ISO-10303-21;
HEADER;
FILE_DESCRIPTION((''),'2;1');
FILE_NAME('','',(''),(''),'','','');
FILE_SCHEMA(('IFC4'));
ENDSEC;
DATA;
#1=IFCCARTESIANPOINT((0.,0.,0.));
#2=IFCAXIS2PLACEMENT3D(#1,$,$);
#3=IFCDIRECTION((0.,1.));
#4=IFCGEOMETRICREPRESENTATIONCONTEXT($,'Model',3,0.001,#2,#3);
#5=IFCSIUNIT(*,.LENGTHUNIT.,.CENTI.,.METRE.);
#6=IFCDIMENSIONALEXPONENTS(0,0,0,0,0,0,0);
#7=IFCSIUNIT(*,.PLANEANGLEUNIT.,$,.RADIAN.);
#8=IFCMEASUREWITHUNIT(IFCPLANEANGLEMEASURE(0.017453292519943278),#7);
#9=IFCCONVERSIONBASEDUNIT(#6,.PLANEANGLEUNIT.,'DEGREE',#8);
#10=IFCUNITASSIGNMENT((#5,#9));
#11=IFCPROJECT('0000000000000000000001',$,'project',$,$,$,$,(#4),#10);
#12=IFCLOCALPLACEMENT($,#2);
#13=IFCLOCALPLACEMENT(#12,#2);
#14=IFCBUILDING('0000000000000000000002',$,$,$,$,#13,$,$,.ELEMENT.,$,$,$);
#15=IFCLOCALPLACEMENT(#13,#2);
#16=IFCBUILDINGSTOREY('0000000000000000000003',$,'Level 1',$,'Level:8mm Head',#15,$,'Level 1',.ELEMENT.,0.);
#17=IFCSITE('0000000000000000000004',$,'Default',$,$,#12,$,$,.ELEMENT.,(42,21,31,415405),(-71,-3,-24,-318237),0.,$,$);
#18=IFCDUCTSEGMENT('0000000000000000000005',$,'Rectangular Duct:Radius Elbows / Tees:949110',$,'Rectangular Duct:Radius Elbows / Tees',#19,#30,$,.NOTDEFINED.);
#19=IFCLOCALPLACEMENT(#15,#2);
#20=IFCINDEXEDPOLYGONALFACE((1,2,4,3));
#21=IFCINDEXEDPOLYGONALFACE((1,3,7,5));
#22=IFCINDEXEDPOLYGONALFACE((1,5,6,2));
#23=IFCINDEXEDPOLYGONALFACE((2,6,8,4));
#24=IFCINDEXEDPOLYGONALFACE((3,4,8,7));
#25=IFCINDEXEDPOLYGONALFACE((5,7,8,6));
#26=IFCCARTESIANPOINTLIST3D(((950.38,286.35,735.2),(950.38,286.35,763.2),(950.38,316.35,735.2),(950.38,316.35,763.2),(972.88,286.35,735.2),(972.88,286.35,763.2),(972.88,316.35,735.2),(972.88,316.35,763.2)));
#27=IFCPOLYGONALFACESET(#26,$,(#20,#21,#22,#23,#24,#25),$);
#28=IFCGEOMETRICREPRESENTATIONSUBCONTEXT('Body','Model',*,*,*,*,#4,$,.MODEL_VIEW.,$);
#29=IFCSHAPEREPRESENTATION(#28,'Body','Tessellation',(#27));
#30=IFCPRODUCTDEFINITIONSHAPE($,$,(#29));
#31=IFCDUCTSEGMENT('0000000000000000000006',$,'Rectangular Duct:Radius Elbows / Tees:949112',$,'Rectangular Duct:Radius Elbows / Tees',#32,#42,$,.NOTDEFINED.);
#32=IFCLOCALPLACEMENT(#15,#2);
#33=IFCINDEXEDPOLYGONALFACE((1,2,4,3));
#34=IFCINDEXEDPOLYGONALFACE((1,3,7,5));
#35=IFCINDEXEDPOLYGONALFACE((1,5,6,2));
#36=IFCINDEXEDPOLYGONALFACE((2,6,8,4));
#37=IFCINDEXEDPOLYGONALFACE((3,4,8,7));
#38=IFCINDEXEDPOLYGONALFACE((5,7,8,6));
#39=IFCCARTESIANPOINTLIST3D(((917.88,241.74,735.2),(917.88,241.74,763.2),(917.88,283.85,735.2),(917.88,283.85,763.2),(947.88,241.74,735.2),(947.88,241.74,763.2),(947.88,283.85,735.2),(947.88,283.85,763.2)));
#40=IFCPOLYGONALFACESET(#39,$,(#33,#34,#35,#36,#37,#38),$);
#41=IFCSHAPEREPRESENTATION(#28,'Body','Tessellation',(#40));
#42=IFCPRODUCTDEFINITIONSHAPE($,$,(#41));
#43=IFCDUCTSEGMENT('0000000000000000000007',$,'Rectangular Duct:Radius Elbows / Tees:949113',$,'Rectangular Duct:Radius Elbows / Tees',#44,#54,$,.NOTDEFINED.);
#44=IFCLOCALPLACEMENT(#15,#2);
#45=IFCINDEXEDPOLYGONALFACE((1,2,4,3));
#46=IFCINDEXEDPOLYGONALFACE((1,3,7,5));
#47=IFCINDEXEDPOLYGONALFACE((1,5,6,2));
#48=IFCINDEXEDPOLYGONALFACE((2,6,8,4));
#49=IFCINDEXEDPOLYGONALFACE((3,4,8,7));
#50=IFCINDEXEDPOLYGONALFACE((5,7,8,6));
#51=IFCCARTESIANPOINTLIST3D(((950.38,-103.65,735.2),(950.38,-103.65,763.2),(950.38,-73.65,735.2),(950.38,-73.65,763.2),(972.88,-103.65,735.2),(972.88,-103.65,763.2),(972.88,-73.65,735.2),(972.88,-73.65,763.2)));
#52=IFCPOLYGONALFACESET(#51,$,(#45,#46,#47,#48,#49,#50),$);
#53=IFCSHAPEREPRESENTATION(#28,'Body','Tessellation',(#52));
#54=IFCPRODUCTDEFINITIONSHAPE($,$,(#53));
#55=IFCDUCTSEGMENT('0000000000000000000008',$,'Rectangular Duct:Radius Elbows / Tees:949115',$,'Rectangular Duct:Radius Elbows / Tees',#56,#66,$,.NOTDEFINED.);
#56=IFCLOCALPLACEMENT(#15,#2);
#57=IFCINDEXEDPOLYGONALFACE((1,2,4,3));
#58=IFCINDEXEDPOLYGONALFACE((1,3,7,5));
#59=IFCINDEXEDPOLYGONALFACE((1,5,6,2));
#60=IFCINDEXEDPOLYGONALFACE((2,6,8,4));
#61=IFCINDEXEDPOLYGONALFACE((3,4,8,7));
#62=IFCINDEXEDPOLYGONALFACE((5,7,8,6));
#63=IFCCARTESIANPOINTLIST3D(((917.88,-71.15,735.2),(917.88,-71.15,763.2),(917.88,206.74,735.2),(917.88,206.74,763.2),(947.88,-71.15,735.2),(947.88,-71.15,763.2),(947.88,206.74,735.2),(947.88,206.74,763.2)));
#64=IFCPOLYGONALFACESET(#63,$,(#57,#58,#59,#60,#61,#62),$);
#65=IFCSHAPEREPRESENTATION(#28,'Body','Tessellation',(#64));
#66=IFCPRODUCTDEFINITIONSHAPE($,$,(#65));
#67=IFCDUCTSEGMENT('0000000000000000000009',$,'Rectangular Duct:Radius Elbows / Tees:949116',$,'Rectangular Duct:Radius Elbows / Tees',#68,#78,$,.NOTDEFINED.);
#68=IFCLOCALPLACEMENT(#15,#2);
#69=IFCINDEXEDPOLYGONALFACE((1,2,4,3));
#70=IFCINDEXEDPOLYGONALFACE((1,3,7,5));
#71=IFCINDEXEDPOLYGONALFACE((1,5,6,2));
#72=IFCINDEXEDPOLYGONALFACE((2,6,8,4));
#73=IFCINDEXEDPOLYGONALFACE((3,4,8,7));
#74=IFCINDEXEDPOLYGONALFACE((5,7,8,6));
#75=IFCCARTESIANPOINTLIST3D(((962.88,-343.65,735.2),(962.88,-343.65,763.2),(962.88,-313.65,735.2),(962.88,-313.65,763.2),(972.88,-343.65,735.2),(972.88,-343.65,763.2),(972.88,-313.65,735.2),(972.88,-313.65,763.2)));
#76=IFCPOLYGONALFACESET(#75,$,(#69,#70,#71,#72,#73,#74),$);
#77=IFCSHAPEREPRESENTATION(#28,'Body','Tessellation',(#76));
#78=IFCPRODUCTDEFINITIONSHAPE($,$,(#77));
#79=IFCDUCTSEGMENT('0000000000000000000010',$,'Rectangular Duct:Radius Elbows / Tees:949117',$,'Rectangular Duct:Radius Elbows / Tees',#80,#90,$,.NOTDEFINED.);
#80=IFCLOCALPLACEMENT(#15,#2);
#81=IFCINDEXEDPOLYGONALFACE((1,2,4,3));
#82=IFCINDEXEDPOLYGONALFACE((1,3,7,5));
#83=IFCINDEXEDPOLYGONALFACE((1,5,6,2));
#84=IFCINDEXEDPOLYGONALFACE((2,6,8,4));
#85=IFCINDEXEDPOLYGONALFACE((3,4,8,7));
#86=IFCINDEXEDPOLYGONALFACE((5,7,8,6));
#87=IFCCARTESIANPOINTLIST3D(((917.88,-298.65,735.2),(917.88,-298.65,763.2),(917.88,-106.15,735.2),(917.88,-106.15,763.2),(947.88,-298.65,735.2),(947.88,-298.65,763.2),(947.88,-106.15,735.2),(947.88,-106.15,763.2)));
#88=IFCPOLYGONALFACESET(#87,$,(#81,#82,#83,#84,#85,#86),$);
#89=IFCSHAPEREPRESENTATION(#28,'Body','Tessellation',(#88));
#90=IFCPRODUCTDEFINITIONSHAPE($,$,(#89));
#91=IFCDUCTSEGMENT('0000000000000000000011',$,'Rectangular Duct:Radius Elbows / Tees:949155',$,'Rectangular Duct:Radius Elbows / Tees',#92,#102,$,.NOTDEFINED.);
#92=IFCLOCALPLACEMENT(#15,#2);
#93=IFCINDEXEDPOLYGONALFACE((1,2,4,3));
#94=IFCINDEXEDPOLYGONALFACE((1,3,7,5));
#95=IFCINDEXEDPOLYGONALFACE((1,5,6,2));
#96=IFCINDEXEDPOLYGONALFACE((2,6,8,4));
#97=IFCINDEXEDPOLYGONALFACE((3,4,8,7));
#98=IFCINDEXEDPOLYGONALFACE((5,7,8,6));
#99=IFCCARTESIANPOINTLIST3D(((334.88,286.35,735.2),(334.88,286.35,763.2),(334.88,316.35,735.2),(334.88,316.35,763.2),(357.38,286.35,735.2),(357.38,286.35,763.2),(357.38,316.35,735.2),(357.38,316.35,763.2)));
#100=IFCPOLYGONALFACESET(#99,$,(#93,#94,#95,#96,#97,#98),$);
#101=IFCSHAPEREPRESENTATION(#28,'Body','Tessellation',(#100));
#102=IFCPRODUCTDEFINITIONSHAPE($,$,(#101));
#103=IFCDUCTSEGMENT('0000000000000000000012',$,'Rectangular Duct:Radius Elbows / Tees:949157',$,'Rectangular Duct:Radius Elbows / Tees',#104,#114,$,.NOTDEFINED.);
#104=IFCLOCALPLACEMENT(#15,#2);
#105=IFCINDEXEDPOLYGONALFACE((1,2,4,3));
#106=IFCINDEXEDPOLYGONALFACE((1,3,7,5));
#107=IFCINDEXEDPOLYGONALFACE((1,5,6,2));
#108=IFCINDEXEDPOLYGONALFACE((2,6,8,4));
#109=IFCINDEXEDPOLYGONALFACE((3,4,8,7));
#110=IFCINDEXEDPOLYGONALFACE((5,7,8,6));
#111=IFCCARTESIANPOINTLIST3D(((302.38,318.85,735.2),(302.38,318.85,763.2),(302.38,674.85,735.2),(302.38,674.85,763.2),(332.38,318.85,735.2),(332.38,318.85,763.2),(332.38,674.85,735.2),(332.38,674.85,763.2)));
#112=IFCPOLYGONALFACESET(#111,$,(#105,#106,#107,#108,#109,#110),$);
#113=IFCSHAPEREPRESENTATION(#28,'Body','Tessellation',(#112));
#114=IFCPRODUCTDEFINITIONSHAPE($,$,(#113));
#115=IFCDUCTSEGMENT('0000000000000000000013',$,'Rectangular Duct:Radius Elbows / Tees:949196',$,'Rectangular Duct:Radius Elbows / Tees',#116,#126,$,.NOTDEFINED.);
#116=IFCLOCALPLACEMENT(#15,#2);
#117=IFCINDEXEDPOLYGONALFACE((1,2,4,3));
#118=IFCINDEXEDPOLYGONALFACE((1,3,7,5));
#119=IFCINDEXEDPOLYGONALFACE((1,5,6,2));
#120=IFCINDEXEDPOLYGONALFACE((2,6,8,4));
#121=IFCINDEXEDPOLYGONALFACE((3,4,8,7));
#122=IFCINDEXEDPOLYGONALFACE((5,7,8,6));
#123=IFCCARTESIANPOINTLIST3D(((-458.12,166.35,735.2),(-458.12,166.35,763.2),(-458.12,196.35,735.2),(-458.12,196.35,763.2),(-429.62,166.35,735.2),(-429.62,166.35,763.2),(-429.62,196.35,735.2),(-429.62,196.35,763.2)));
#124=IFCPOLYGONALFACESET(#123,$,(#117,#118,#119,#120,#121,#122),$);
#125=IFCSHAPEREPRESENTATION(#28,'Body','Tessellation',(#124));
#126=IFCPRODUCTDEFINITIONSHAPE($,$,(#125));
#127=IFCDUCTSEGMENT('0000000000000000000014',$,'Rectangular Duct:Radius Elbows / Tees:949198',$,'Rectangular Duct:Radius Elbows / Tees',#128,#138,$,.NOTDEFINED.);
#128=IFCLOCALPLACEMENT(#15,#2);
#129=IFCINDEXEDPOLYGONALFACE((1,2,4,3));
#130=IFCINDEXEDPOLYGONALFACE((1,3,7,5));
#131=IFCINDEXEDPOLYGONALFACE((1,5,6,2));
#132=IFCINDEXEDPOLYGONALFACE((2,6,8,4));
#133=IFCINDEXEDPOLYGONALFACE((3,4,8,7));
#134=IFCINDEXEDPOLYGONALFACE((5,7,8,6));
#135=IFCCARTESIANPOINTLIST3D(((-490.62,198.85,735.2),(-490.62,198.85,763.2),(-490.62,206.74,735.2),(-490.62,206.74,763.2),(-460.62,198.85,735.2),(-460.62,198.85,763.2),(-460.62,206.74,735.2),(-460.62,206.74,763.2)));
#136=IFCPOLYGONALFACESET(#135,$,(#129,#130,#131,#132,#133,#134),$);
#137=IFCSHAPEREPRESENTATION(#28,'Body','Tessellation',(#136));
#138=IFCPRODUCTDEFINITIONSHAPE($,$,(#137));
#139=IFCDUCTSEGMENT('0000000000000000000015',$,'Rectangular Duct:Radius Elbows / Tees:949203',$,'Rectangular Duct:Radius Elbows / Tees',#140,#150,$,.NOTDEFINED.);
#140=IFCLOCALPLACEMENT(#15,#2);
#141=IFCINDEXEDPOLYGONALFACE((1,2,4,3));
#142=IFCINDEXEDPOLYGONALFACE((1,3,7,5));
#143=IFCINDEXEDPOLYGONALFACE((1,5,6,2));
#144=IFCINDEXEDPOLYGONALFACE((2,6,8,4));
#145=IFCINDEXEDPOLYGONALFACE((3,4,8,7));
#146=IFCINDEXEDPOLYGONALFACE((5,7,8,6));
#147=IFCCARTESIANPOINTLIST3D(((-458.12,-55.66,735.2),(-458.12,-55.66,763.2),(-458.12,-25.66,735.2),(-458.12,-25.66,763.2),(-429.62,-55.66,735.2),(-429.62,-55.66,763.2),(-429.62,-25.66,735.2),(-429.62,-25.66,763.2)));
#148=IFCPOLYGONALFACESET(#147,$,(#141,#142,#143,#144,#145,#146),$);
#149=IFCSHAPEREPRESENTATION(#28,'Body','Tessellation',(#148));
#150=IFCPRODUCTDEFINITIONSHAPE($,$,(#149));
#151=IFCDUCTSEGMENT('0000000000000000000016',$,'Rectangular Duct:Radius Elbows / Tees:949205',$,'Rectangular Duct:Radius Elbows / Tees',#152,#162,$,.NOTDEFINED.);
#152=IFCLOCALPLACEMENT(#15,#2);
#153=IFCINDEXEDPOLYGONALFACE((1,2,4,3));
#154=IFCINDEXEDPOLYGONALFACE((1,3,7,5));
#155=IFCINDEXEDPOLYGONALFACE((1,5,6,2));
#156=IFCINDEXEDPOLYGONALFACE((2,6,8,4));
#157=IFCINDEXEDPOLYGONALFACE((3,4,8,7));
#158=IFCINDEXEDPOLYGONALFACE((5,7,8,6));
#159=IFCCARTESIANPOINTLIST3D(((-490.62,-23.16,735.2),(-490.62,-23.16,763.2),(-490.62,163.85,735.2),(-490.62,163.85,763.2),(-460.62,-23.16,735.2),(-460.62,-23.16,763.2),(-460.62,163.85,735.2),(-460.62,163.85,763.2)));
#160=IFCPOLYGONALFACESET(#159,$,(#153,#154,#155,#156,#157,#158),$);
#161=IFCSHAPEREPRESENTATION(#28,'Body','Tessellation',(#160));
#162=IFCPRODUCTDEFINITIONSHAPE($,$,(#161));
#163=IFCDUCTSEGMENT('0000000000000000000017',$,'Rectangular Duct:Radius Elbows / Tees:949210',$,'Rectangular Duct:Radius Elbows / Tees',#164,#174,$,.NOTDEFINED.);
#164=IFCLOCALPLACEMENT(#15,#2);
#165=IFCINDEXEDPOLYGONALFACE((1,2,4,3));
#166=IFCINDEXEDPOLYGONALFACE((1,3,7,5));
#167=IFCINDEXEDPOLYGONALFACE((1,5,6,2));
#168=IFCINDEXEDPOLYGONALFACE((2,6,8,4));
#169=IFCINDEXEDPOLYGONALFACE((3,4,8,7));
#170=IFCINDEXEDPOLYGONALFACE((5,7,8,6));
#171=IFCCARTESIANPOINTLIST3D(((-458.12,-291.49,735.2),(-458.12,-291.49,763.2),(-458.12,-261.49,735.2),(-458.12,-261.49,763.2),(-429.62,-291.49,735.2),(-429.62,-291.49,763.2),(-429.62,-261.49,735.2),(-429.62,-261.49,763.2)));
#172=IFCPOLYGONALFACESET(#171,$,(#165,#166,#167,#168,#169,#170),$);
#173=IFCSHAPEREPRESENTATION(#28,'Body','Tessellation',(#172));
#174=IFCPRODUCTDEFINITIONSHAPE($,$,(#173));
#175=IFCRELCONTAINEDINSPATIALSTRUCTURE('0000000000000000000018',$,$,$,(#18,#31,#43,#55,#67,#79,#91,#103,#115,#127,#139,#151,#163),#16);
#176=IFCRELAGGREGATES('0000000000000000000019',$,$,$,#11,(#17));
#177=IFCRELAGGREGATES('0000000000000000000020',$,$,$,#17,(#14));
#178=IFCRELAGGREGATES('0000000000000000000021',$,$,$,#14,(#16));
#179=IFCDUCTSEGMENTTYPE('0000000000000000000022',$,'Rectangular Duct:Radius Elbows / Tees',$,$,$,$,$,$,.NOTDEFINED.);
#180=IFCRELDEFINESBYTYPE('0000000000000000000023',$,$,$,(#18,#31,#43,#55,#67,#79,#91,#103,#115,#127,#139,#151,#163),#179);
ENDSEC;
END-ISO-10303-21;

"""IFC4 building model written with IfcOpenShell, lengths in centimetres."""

from ifc_helpers import new_model, entity, si_unit, converted_unit, direction, frame, origin, place, context, subcontext, project, spatial, indexed_curve, outline, extrude, type_object, element, save


model = new_model("IFC4")

# Units and contexts
model_context = context("Model", 3, precision=0.001, world=origin(), true_north=direction((0.0, 1.0)))
body_context = subcontext(model_context, "Body", "Model", "MODEL_VIEW")
ifc_project = project(units=[si_unit("LENGTHUNIT", "METRE", prefix="CENTI"), converted_unit("PLANEANGLEUNIT", "DEGREE", entity("IfcPlaneAngleMeasure", 0.017453292519943278), si_unit("PLANEANGLEUNIT", "RADIAN"), dimensions=[0, 0, 0, 0, 0, 0, 0])], contexts=[model_context])

# Site, building, storey
site_placement = place(None, origin())
site = spatial("IfcSite", under=ifc_project, at=site_placement, Name="Default", CompositionType="ELEMENT", RefLatitude=(42, 21, 31, 415405), RefLongitude=(-71, -3, -24, -318237), RefElevation=0.0)
building_placement = place(site_placement, origin())
building = spatial("IfcBuilding", under=site, at=building_placement, CompositionType="ELEMENT")
storey_placement = place(building_placement, origin())
storey = spatial("IfcBuildingStorey", under=building, at=storey_placement, Name="Level 1", ObjectType="Level:8mm Head", LongName="Level 1", CompositionType="ELEMENT", Elevation=0.0)

# Duct segments
duct_segment_type_1 = type_object("IfcDuctSegmentType", Name="Rectangular Duct:Radius Elbows / Tees", PredefinedType="NOTDEFINED")
duct_segment_1_placement = place(storey_placement, origin())
element("IfcDuctSegment", 1, at=duct_segment_1_placement, inside=storey, type_object=duct_segment_type_1, Name="Rectangular Duct:Radius Elbows / Tees:949110", ObjectType="Rectangular Duct:Radius Elbows / Tees", PredefinedType="NOTDEFINED", context=body_context, shape_type="SweptSolid", body=[
    extrude(outline(indexed_curve([(-11.25, -15.0), (11.25, -15.0), (11.25, 15.0), (-11.25, 15.0), (-11.25, -15.0)], self_intersect=False)), frame((961.63, 301.35, 735.2)), (0.0, 0.0, 1.0), 28.0),
])
duct_segment_2_placement = place(storey_placement, origin())
element("IfcDuctSegment", 2, at=duct_segment_2_placement, inside=storey, type_object=duct_segment_type_1, Name="Rectangular Duct:Radius Elbows / Tees:949112", ObjectType="Rectangular Duct:Radius Elbows / Tees", PredefinedType="NOTDEFINED", context=body_context, shape_type="SweptSolid", body=[
    extrude(outline(indexed_curve([(-21.05, -15.0), (21.05, -15.0), (21.05, 15.0), (-21.05, 15.0), (-21.05, -15.0)], self_intersect=False)), frame((932.88, 262.79, 735.2), z_axis=(0.0, 0.0, 1.0), x_axis=(0.0, 1.0, 0.0)), (0.0, 0.0, 1.0), 28.0),
])
duct_segment_3_placement = place(storey_placement, origin())
element("IfcDuctSegment", 3, at=duct_segment_3_placement, inside=storey, type_object=duct_segment_type_1, Name="Rectangular Duct:Radius Elbows / Tees:949113", ObjectType="Rectangular Duct:Radius Elbows / Tees", PredefinedType="NOTDEFINED", context=body_context, shape_type="SweptSolid", body=[
    extrude(outline(indexed_curve([(-11.25, -15.0), (11.25, -15.0), (11.25, 15.0), (-11.25, 15.0), (-11.25, -15.0)], self_intersect=False)), frame((961.63, -88.65, 735.2)), (0.0, 0.0, 1.0), 28.0),
])
duct_segment_4_placement = place(storey_placement, origin())
element("IfcDuctSegment", 4, at=duct_segment_4_placement, inside=storey, type_object=duct_segment_type_1, Name="Rectangular Duct:Radius Elbows / Tees:949115", ObjectType="Rectangular Duct:Radius Elbows / Tees", PredefinedType="NOTDEFINED", context=body_context, shape_type="SweptSolid", body=[
    extrude(outline(indexed_curve([(-138.95, -15.0), (138.95, -15.0), (138.95, 15.0), (-138.95, 15.0), (-138.95, -15.0)], self_intersect=False)), frame((932.88, 67.79, 735.2), z_axis=(0.0, 0.0, 1.0), x_axis=(0.0, -1.0, 0.0)), (0.0, 0.0, 1.0), 28.0),
])
duct_segment_5_placement = place(storey_placement, origin())
element("IfcDuctSegment", 5, at=duct_segment_5_placement, inside=storey, type_object=duct_segment_type_1, Name="Rectangular Duct:Radius Elbows / Tees:949116", ObjectType="Rectangular Duct:Radius Elbows / Tees", PredefinedType="NOTDEFINED", context=body_context, shape_type="SweptSolid", body=[
    extrude(outline(indexed_curve([(-5.0, -15.0), (5.0, -15.0), (5.0, 15.0), (-5.0, 15.0), (-5.0, -15.0)], self_intersect=False)), frame((967.88, -328.65, 735.2)), (0.0, 0.0, 1.0), 28.0),
])
duct_segment_6_placement = place(storey_placement, origin())
element("IfcDuctSegment", 6, at=duct_segment_6_placement, inside=storey, type_object=duct_segment_type_1, Name="Rectangular Duct:Radius Elbows / Tees:949117", ObjectType="Rectangular Duct:Radius Elbows / Tees", PredefinedType="NOTDEFINED", context=body_context, shape_type="SweptSolid", body=[
    extrude(outline(indexed_curve([(-96.25, -15.0), (96.25, -15.0), (96.25, 15.0), (-96.25, 15.0), (-96.25, -15.0)], self_intersect=False)), frame((932.88, -202.4, 735.2), z_axis=(0.0, 0.0, 1.0), x_axis=(0.0, -1.0, 0.0)), (0.0, 0.0, 1.0), 28.0),
])
duct_segment_7_placement = place(storey_placement, origin())
element("IfcDuctSegment", 7, at=duct_segment_7_placement, inside=storey, type_object=duct_segment_type_1, Name="Rectangular Duct:Radius Elbows / Tees:949155", ObjectType="Rectangular Duct:Radius Elbows / Tees", PredefinedType="NOTDEFINED", context=body_context, shape_type="SweptSolid", body=[
    extrude(outline(indexed_curve([(-11.25, -15.0), (11.25, -15.0), (11.25, 15.0), (-11.25, 15.0), (-11.25, -15.0)], self_intersect=False)), frame((346.13, 301.35, 735.2)), (0.0, 0.0, 1.0), 28.0),
])
duct_segment_8_placement = place(storey_placement, origin())
element("IfcDuctSegment", 8, at=duct_segment_8_placement, inside=storey, type_object=duct_segment_type_1, Name="Rectangular Duct:Radius Elbows / Tees:949157", ObjectType="Rectangular Duct:Radius Elbows / Tees", PredefinedType="NOTDEFINED", context=body_context, shape_type="SweptSolid", body=[
    extrude(outline(indexed_curve([(-178.0, -15.0), (178.0, -15.0), (178.0, 15.0), (-178.0, 15.0), (-178.0, -15.0)], self_intersect=False)), frame((317.38, 496.85, 735.2), z_axis=(0.0, 0.0, 1.0), x_axis=(0.0, -1.0, 0.0)), (0.0, 0.0, 1.0), 28.0),
])
duct_segment_9_placement = place(storey_placement, origin())
element("IfcDuctSegment", 9, at=duct_segment_9_placement, inside=storey, type_object=duct_segment_type_1, Name="Rectangular Duct:Radius Elbows / Tees:949196", ObjectType="Rectangular Duct:Radius Elbows / Tees", PredefinedType="NOTDEFINED", context=body_context, shape_type="SweptSolid", body=[
    extrude(outline(indexed_curve([(-14.25, -15.0), (14.25, -15.0), (14.25, 15.0), (-14.25, 15.0), (-14.25, -15.0)], self_intersect=False)), frame((-443.87, 181.35, 735.2)), (0.0, 0.0, 1.0), 28.0),
])
duct_segment_10_placement = place(storey_placement, origin())
element("IfcDuctSegment", 10, at=duct_segment_10_placement, inside=storey, type_object=duct_segment_type_1, Name="Rectangular Duct:Radius Elbows / Tees:949198", ObjectType="Rectangular Duct:Radius Elbows / Tees", PredefinedType="NOTDEFINED", context=body_context, shape_type="SweptSolid", body=[
    extrude(outline(indexed_curve([(-3.95, -15.0), (3.95, -15.0), (3.95, 15.0), (-3.95, 15.0), (-3.95, -15.0)], self_intersect=False)), frame((-475.62, 202.79, 735.2), z_axis=(0.0, 0.0, 1.0), x_axis=(0.0, -1.0, 0.0)), (0.0, 0.0, 1.0), 28.0),
])
duct_segment_11_placement = place(storey_placement, origin())
element("IfcDuctSegment", 11, at=duct_segment_11_placement, inside=storey, type_object=duct_segment_type_1, Name="Rectangular Duct:Radius Elbows / Tees:949203", ObjectType="Rectangular Duct:Radius Elbows / Tees", PredefinedType="NOTDEFINED", context=body_context, shape_type="SweptSolid", body=[
    extrude(outline(indexed_curve([(-14.25, -15.0), (14.25, -15.0), (14.25, 15.0), (-14.25, 15.0), (-14.25, -15.0)], self_intersect=False)), frame((-443.87, -40.66, 735.2)), (0.0, 0.0, 1.0), 28.0),
])
duct_segment_12_placement = place(storey_placement, origin())
element("IfcDuctSegment", 12, at=duct_segment_12_placement, inside=storey, type_object=duct_segment_type_1, Name="Rectangular Duct:Radius Elbows / Tees:949205", ObjectType="Rectangular Duct:Radius Elbows / Tees", PredefinedType="NOTDEFINED", context=body_context, shape_type="SweptSolid", body=[
    extrude(outline(indexed_curve([(-93.5, -15.0), (93.5, -15.0), (93.5, 15.0), (-93.5, 15.0), (-93.5, -15.0)], self_intersect=False)), frame((-475.62, 70.34, 735.2), z_axis=(0.0, 0.0, 1.0), x_axis=(0.0, -1.0, 0.0)), (0.0, 0.0, 1.0), 28.0),
])
duct_segment_13_placement = place(storey_placement, origin())
element("IfcDuctSegment", 13, at=duct_segment_13_placement, inside=storey, type_object=duct_segment_type_1, Name="Rectangular Duct:Radius Elbows / Tees:949210", ObjectType="Rectangular Duct:Radius Elbows / Tees", PredefinedType="NOTDEFINED", context=body_context, shape_type="SweptSolid", body=[
    extrude(outline(indexed_curve([(-14.25, -15.0), (14.25, -15.0), (14.25, 15.0), (-14.25, 15.0), (-14.25, -15.0)], self_intersect=False)), frame((-443.87, -276.49, 735.2)), (0.0, 0.0, 1.0), 28.0),
])

save(model, "model.ifc")
